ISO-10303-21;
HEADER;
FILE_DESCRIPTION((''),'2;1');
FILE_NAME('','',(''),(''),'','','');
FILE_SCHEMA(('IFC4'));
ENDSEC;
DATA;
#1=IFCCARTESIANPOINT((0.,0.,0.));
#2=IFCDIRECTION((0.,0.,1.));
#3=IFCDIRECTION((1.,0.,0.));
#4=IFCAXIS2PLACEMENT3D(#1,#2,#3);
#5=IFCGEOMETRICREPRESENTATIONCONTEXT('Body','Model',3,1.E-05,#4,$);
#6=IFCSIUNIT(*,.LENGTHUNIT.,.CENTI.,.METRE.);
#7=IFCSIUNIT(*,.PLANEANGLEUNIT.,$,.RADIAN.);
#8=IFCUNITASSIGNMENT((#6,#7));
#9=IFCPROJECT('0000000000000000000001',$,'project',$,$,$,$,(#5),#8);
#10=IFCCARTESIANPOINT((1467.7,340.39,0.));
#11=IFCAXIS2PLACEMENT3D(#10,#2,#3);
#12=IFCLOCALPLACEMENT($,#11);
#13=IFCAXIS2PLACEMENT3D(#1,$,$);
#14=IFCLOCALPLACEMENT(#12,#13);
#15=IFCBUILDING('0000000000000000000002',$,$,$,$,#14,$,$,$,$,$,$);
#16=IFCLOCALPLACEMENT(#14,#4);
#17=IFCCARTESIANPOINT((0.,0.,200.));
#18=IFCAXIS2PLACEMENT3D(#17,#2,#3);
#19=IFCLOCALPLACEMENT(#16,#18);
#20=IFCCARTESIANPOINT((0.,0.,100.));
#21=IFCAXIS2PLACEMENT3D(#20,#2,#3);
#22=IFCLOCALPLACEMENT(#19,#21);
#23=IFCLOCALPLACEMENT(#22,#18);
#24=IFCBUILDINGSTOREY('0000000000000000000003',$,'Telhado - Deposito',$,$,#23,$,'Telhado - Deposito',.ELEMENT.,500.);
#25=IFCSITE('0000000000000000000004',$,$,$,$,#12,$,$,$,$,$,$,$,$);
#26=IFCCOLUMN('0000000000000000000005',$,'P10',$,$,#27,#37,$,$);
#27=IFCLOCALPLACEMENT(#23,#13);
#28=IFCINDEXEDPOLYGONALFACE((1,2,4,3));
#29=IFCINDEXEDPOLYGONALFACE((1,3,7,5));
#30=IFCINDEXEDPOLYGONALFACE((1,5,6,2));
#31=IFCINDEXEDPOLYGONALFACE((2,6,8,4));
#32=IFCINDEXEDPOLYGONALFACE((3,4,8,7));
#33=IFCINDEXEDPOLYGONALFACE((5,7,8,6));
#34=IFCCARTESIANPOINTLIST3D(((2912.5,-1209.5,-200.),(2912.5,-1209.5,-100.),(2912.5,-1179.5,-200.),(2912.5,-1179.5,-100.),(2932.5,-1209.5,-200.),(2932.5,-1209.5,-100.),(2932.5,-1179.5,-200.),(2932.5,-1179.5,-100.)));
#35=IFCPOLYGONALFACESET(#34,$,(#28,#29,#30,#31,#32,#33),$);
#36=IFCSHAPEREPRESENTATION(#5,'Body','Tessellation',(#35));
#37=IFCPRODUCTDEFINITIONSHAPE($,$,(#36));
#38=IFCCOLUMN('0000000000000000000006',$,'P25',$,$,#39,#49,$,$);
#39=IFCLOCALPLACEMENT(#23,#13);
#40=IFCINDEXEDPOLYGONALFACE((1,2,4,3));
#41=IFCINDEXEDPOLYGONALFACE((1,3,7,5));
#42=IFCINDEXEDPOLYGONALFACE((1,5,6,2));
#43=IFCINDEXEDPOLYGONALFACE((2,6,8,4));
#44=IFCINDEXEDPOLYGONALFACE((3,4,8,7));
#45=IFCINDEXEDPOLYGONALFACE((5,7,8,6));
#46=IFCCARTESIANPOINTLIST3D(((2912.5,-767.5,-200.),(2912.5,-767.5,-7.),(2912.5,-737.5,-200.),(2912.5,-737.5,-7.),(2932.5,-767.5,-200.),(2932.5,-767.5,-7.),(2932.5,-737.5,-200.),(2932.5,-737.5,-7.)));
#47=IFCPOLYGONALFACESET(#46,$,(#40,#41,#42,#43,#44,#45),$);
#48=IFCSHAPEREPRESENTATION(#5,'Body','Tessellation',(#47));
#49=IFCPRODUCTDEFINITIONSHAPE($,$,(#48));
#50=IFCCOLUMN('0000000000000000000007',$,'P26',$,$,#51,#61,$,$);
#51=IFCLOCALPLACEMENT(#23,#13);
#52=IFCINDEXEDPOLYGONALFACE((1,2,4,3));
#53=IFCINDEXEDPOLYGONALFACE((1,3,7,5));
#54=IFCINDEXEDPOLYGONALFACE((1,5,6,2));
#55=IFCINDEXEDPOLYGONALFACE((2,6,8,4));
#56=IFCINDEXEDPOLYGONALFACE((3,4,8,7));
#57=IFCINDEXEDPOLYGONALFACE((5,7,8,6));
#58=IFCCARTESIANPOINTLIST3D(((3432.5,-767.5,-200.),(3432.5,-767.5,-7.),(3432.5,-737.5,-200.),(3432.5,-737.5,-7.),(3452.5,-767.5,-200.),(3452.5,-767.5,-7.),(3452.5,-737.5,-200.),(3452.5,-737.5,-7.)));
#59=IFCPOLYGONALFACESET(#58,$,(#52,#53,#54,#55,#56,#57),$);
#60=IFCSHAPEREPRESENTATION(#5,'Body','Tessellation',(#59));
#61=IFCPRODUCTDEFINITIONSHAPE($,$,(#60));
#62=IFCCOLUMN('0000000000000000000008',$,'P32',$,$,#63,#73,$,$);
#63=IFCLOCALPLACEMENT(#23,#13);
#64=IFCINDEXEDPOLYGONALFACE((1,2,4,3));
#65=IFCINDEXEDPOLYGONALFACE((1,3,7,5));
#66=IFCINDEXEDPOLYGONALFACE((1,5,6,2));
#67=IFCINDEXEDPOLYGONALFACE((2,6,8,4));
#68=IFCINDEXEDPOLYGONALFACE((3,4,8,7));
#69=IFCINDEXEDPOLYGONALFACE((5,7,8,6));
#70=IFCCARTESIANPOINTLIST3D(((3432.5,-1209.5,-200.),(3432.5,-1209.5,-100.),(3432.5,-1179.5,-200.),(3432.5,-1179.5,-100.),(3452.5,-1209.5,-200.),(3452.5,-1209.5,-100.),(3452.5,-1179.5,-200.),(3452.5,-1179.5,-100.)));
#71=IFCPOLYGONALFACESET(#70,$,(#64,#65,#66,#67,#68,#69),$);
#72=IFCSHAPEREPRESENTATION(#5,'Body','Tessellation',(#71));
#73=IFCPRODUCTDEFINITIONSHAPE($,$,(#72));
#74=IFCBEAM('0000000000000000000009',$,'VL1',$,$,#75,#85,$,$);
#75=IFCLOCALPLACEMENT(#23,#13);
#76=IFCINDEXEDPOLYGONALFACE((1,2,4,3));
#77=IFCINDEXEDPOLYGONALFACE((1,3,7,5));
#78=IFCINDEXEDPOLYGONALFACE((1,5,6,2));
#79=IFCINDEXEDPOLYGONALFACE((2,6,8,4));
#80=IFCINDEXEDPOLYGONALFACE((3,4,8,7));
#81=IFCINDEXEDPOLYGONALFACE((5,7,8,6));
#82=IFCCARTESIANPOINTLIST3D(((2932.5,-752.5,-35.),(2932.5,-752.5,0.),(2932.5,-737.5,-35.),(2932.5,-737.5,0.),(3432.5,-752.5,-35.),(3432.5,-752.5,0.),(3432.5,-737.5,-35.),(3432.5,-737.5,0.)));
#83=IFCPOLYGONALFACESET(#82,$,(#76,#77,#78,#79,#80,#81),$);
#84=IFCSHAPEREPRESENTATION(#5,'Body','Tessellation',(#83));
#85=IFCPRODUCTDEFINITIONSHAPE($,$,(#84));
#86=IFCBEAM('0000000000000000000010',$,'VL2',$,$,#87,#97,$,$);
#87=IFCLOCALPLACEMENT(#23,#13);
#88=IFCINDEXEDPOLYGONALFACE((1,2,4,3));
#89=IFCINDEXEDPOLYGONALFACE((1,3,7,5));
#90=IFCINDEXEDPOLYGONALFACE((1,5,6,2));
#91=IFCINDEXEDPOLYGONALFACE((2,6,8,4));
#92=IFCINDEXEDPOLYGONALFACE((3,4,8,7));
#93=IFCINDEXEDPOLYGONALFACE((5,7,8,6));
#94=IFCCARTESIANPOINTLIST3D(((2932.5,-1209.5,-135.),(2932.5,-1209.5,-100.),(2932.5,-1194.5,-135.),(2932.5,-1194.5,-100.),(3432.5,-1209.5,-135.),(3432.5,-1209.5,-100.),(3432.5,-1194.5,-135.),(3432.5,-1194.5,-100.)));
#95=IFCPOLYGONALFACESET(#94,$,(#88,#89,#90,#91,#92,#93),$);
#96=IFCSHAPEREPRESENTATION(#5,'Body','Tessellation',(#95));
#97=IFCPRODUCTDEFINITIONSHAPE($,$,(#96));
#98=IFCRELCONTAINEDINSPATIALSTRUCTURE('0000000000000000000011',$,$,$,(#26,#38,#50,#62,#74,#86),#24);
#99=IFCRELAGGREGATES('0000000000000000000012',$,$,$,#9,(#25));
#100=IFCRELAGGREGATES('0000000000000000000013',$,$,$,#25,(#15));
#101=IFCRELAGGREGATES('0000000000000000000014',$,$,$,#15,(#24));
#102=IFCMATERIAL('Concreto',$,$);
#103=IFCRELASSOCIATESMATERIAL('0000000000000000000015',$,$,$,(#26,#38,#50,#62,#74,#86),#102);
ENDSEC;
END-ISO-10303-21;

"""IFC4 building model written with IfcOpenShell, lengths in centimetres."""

from ifc_helpers import new_model, si_unit, frame, origin, origin_with_axes, origin_2d_with_axis, place, context, project, spatial, rectangle, extrude, material, element, save


model = new_model("IFC4")

# Units and contexts
model_context = context("Model", 3, precision=1e-05, world=origin_with_axes(), identifier="Body")
ifc_project = project(units=[si_unit("LENGTHUNIT", "METRE", prefix="CENTI"), si_unit("PLANEANGLEUNIT", "RADIAN")], contexts=[model_context])

# Site, building, storey
site_placement = place(None, frame((1467.7, 340.39, 0.0), z_axis=(0.0, 0.0, 1.0), x_axis=(1.0, 0.0, 0.0)))
site = spatial("IfcSite", under=ifc_project, at=site_placement)
building_placement = place(site_placement, origin())
building = spatial("IfcBuilding", under=site, at=building_placement)
placement_1 = place(building_placement, origin_with_axes())
placement_2 = place(placement_1, frame((0.0, 0.0, 200.0), z_axis=(0.0, 0.0, 1.0), x_axis=(1.0, 0.0, 0.0)))
placement_3 = place(placement_2, frame((0.0, 0.0, 100.0), z_axis=(0.0, 0.0, 1.0), x_axis=(1.0, 0.0, 0.0)))
storey_placement = place(placement_3, frame((0.0, 0.0, 200.0), z_axis=(0.0, 0.0, 1.0), x_axis=(1.0, 0.0, 0.0)))
storey = spatial("IfcBuildingStorey", under=building, at=storey_placement, Name="Telhado - Deposito", LongName="Telhado - Deposito", CompositionType="ELEMENT", Elevation=500.0)

# Columns
ifc_material = material(Name="Concreto")
column_1_placement = place(storey_placement, frame((2922.5, -1194.5, -100.0), z_axis=(0.0, 0.0, 1.0), x_axis=(1.0, 0.0, 0.0)))
element("IfcColumn", 1, at=column_1_placement, inside=storey, material=ifc_material, Name="P10", context=model_context, shape_type="SolidModel", body=[
    extrude(rectangle(XDim=20.0, YDim=30.0, at=origin_2d_with_axis()), origin_with_axes(), (0.0, 0.0, -1.0), 100.0),
])
column_2_placement = place(storey_placement, frame((2922.5, -752.5, -7.0), z_axis=(0.0, 0.0, 1.0), x_axis=(1.0, 0.0, 0.0)))
element("IfcColumn", 2, at=column_2_placement, inside=storey, material=ifc_material, Name="P25", context=model_context, shape_type="SolidModel", body=[
    extrude(rectangle(XDim=20.0, YDim=30.0, at=origin_2d_with_axis()), frame((0.0, 0.0, 0.0), z_axis=(0.0, 0.0, 1.0), x_axis=(-1.0, 0.0, 0.0)), (0.0, 0.0, -1.0), 193.0),
])
column_3_placement = place(storey_placement, frame((3442.5, -752.5, -7.0), z_axis=(0.0, 0.0, 1.0), x_axis=(1.0, 0.0, 0.0)))
element("IfcColumn", 3, at=column_3_placement, inside=storey, material=ifc_material, Name="P26", context=model_context, shape_type="SolidModel", body=[
    extrude(rectangle(XDim=20.0, YDim=30.0, at=origin_2d_with_axis()), origin_with_axes(), (0.0, 0.0, -1.0), 193.0),
])
column_4_placement = place(storey_placement, frame((3442.5, -1194.5, -100.0), z_axis=(0.0, 0.0, 1.0), x_axis=(1.0, 0.0, 0.0)))
element("IfcColumn", 4, at=column_4_placement, inside=storey, material=ifc_material, Name="P32", context=model_context, shape_type="SolidModel", body=[
    extrude(rectangle(XDim=20.0, YDim=30.0, at=origin_2d_with_axis()), origin_with_axes(), (0.0, 0.0, -1.0), 100.0),
])

# Beams
for number, where, z_axis, x_axis, name in (
    (5, (3182.5, -745.0, 0.0), (0.0, 0.0, 1.0), (1.0, 0.0, 0.0), "VL1"),
    (6, (3182.5, -1202.0, -100.0), (0.0, 0.0, 1.0), (1.0, 0.0, 0.0), "VL2"),
):
    element("IfcBeam", number, at=place(storey_placement, frame(where, z_axis=z_axis, x_axis=x_axis)), inside=storey, material=ifc_material, Name=name, context=model_context, shape_type="SolidModel", body=[
        extrude(rectangle(XDim=15.0, YDim=35.0, at=origin_2d_with_axis()), frame((-250.0, 0.0, -17.5), z_axis=(1.0, 0.0, 0.0), x_axis=(0.0, 1.0, 0.0)), (0.0, 0.0, 1.0), 500.0),
    ])

save(model, "model.ifc")
